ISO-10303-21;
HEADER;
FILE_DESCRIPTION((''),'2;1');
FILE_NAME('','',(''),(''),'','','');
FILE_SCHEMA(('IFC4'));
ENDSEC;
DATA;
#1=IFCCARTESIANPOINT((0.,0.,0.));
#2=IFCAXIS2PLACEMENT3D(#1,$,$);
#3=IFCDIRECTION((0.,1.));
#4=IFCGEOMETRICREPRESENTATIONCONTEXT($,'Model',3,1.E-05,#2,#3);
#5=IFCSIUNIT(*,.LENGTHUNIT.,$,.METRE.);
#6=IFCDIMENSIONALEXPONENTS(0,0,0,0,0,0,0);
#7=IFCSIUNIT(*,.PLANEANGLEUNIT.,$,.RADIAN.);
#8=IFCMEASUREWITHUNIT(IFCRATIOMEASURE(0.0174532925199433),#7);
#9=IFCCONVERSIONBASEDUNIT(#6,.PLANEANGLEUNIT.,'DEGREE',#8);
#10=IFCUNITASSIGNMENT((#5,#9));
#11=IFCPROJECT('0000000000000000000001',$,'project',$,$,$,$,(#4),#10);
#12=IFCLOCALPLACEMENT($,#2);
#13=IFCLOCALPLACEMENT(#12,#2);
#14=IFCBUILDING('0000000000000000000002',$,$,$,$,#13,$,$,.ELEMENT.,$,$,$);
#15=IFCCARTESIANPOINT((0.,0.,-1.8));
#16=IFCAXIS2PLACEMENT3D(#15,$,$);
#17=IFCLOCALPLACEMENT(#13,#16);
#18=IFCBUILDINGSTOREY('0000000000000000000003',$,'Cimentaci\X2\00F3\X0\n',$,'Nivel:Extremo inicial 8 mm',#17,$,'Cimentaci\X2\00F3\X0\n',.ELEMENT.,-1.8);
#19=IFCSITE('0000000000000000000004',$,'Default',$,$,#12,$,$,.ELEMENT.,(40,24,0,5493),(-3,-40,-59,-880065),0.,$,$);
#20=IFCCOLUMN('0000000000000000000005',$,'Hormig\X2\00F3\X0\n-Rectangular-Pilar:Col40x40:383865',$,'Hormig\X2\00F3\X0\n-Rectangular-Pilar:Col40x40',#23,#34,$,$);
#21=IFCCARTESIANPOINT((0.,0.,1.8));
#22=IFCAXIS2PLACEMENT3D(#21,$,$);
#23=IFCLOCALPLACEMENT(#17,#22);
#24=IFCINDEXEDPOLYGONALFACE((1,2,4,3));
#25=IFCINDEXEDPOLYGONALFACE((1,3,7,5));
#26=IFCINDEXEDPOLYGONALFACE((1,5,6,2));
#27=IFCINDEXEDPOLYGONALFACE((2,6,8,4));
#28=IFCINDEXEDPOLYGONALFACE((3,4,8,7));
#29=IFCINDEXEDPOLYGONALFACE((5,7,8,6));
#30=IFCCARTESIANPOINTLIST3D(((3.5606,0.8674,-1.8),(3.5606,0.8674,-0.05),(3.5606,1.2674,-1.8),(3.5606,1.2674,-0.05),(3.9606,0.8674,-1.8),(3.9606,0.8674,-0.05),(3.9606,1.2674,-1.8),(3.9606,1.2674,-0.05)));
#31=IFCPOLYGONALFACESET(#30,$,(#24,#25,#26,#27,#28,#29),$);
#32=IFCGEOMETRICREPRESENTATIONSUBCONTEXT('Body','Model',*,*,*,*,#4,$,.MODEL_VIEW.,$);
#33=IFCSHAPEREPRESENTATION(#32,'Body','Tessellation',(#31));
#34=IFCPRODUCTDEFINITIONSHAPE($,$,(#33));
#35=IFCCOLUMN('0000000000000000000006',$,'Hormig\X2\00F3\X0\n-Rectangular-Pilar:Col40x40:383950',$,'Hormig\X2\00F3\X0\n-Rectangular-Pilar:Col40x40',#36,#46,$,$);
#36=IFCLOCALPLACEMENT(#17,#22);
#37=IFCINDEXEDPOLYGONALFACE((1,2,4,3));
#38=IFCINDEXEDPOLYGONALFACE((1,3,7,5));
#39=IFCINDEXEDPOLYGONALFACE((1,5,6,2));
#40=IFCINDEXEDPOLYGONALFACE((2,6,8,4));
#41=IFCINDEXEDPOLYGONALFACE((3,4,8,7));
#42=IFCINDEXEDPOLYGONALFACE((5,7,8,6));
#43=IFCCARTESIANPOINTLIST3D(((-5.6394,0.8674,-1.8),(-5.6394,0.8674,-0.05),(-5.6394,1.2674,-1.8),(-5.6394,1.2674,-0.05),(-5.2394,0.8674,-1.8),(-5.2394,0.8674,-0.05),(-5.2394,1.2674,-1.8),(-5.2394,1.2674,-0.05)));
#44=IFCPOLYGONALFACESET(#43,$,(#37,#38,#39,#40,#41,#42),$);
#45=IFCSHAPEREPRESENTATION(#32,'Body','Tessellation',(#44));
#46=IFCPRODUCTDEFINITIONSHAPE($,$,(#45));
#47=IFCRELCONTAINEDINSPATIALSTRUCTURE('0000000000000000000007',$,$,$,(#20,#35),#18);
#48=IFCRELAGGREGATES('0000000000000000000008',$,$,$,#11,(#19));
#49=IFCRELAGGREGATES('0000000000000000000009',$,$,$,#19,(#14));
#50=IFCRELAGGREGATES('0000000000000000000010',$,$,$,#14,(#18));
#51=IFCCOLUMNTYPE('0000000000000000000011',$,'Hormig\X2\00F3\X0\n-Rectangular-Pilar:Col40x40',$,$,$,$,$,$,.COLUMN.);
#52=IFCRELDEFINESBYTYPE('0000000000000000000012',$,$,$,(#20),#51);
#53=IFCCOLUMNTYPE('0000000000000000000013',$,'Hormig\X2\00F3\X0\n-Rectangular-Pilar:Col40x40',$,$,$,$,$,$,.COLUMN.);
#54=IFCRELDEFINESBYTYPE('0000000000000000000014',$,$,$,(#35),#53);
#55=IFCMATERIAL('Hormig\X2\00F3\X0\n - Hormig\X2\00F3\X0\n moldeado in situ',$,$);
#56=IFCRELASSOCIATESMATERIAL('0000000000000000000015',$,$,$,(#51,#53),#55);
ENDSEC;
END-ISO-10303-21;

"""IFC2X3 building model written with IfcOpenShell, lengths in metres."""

from ifc_helpers import new_model, entity, si_unit, converted_unit, direction, frame, origin, origin_2d_with_axis, place, context, subcontext, project, spatial, rectangle, extrude, source, transform, mapped, material, type_object, type_shapes, element, save


model = new_model("IFC2X3")

# Units and contexts
model_context = context("Model", 3, precision=1e-05, world=origin(), true_north=direction((0.0, 1.0)))
body_context = subcontext(model_context, "Body", "Model", "MODEL_VIEW")
ifc_project = project(units=[si_unit("LENGTHUNIT", "METRE"), converted_unit("PLANEANGLEUNIT", "DEGREE", entity("IfcRatioMeasure", 0.0174532925199433), si_unit("PLANEANGLEUNIT", "RADIAN"), dimensions=[0, 0, 0, 0, 0, 0, 0])], contexts=[model_context])

# Site, building, storey
site_placement = place(None, origin())
site = spatial("IfcSite", under=ifc_project, at=site_placement, Name="Default", CompositionType="ELEMENT", RefLatitude=(40, 24, 0, 5493), RefLongitude=(-3, -40, -59, -880065), RefElevation=0.0)
building_placement = place(site_placement, origin())
building = spatial("IfcBuilding", under=site, at=building_placement, CompositionType="ELEMENT")
storey_placement = place(building_placement, frame((0.0, 0.0, -1.8)))
storey = spatial("IfcBuildingStorey", under=building, at=storey_placement, Name="Cimentación", ObjectType="Nivel:Extremo inicial 8 mm", LongName="Cimentación", CompositionType="ELEMENT", Elevation=-1.8)

# Shared definitions
ifc_material_1 = material(Name="Hormigón - Hormigón moldeado in situ")

# Columns
column_type_1 = type_object("IfcColumnType", Name="Hormigón-Rectangular-Pilar:Col40x40", PredefinedType="COLUMN", material=ifc_material_1)
shared_shape_1 = source(origin(), body_context, "Body", "SweptSolid", [
    extrude(rectangle(XDim=0.4, YDim=0.4, at=origin_2d_with_axis()), frame((3.7606, 1.0674, -1.8), z_axis=(0.0, 0.0, 1.0), x_axis=(0.0, -1.0, 0.0)), (0.0, 0.0, 1.0), 1.75),
])
type_shapes(column_type_1, [shared_shape_1])
column_1_placement = place(storey_placement, frame((0.0, 0.0, 1.8)))
element("IfcColumn", 1, at=column_1_placement, inside=storey, type_object=column_type_1, Name="Hormigón-Rectangular-Pilar:Col40x40:383865", ObjectType="Hormigón-Rectangular-Pilar:Col40x40", context=body_context, shape_type="MappedRepresentation", body=[
    mapped(shared_shape_1, transform((0.0, 0.0, 0.0), scale=1.0)),
])
column_type_2 = type_object("IfcColumnType", Name="Hormigón-Rectangular-Pilar:Col40x40", PredefinedType="COLUMN", material=ifc_material_1)
shared_shape_2 = source(origin(), body_context, "Body", "SweptSolid", [
    extrude(rectangle(XDim=0.4, YDim=0.4, at=origin_2d_with_axis()), frame((-5.4394, 1.0674, -1.8), z_axis=(0.0, 0.0, 1.0), x_axis=(0.0, -1.0, 0.0)), (0.0, 0.0, 1.0), 1.75),
])
type_shapes(column_type_2, [shared_shape_2])
column_2_placement = place(storey_placement, frame((0.0, 0.0, 1.8)))
element("IfcColumn", 2, at=column_2_placement, inside=storey, type_object=column_type_2, Name="Hormigón-Rectangular-Pilar:Col40x40:383950", ObjectType="Hormigón-Rectangular-Pilar:Col40x40", context=body_context, shape_type="MappedRepresentation", body=[
    mapped(shared_shape_2, transform((0.0, 0.0, 0.0), scale=1.0)),
])

save(model, "model.ifc")
